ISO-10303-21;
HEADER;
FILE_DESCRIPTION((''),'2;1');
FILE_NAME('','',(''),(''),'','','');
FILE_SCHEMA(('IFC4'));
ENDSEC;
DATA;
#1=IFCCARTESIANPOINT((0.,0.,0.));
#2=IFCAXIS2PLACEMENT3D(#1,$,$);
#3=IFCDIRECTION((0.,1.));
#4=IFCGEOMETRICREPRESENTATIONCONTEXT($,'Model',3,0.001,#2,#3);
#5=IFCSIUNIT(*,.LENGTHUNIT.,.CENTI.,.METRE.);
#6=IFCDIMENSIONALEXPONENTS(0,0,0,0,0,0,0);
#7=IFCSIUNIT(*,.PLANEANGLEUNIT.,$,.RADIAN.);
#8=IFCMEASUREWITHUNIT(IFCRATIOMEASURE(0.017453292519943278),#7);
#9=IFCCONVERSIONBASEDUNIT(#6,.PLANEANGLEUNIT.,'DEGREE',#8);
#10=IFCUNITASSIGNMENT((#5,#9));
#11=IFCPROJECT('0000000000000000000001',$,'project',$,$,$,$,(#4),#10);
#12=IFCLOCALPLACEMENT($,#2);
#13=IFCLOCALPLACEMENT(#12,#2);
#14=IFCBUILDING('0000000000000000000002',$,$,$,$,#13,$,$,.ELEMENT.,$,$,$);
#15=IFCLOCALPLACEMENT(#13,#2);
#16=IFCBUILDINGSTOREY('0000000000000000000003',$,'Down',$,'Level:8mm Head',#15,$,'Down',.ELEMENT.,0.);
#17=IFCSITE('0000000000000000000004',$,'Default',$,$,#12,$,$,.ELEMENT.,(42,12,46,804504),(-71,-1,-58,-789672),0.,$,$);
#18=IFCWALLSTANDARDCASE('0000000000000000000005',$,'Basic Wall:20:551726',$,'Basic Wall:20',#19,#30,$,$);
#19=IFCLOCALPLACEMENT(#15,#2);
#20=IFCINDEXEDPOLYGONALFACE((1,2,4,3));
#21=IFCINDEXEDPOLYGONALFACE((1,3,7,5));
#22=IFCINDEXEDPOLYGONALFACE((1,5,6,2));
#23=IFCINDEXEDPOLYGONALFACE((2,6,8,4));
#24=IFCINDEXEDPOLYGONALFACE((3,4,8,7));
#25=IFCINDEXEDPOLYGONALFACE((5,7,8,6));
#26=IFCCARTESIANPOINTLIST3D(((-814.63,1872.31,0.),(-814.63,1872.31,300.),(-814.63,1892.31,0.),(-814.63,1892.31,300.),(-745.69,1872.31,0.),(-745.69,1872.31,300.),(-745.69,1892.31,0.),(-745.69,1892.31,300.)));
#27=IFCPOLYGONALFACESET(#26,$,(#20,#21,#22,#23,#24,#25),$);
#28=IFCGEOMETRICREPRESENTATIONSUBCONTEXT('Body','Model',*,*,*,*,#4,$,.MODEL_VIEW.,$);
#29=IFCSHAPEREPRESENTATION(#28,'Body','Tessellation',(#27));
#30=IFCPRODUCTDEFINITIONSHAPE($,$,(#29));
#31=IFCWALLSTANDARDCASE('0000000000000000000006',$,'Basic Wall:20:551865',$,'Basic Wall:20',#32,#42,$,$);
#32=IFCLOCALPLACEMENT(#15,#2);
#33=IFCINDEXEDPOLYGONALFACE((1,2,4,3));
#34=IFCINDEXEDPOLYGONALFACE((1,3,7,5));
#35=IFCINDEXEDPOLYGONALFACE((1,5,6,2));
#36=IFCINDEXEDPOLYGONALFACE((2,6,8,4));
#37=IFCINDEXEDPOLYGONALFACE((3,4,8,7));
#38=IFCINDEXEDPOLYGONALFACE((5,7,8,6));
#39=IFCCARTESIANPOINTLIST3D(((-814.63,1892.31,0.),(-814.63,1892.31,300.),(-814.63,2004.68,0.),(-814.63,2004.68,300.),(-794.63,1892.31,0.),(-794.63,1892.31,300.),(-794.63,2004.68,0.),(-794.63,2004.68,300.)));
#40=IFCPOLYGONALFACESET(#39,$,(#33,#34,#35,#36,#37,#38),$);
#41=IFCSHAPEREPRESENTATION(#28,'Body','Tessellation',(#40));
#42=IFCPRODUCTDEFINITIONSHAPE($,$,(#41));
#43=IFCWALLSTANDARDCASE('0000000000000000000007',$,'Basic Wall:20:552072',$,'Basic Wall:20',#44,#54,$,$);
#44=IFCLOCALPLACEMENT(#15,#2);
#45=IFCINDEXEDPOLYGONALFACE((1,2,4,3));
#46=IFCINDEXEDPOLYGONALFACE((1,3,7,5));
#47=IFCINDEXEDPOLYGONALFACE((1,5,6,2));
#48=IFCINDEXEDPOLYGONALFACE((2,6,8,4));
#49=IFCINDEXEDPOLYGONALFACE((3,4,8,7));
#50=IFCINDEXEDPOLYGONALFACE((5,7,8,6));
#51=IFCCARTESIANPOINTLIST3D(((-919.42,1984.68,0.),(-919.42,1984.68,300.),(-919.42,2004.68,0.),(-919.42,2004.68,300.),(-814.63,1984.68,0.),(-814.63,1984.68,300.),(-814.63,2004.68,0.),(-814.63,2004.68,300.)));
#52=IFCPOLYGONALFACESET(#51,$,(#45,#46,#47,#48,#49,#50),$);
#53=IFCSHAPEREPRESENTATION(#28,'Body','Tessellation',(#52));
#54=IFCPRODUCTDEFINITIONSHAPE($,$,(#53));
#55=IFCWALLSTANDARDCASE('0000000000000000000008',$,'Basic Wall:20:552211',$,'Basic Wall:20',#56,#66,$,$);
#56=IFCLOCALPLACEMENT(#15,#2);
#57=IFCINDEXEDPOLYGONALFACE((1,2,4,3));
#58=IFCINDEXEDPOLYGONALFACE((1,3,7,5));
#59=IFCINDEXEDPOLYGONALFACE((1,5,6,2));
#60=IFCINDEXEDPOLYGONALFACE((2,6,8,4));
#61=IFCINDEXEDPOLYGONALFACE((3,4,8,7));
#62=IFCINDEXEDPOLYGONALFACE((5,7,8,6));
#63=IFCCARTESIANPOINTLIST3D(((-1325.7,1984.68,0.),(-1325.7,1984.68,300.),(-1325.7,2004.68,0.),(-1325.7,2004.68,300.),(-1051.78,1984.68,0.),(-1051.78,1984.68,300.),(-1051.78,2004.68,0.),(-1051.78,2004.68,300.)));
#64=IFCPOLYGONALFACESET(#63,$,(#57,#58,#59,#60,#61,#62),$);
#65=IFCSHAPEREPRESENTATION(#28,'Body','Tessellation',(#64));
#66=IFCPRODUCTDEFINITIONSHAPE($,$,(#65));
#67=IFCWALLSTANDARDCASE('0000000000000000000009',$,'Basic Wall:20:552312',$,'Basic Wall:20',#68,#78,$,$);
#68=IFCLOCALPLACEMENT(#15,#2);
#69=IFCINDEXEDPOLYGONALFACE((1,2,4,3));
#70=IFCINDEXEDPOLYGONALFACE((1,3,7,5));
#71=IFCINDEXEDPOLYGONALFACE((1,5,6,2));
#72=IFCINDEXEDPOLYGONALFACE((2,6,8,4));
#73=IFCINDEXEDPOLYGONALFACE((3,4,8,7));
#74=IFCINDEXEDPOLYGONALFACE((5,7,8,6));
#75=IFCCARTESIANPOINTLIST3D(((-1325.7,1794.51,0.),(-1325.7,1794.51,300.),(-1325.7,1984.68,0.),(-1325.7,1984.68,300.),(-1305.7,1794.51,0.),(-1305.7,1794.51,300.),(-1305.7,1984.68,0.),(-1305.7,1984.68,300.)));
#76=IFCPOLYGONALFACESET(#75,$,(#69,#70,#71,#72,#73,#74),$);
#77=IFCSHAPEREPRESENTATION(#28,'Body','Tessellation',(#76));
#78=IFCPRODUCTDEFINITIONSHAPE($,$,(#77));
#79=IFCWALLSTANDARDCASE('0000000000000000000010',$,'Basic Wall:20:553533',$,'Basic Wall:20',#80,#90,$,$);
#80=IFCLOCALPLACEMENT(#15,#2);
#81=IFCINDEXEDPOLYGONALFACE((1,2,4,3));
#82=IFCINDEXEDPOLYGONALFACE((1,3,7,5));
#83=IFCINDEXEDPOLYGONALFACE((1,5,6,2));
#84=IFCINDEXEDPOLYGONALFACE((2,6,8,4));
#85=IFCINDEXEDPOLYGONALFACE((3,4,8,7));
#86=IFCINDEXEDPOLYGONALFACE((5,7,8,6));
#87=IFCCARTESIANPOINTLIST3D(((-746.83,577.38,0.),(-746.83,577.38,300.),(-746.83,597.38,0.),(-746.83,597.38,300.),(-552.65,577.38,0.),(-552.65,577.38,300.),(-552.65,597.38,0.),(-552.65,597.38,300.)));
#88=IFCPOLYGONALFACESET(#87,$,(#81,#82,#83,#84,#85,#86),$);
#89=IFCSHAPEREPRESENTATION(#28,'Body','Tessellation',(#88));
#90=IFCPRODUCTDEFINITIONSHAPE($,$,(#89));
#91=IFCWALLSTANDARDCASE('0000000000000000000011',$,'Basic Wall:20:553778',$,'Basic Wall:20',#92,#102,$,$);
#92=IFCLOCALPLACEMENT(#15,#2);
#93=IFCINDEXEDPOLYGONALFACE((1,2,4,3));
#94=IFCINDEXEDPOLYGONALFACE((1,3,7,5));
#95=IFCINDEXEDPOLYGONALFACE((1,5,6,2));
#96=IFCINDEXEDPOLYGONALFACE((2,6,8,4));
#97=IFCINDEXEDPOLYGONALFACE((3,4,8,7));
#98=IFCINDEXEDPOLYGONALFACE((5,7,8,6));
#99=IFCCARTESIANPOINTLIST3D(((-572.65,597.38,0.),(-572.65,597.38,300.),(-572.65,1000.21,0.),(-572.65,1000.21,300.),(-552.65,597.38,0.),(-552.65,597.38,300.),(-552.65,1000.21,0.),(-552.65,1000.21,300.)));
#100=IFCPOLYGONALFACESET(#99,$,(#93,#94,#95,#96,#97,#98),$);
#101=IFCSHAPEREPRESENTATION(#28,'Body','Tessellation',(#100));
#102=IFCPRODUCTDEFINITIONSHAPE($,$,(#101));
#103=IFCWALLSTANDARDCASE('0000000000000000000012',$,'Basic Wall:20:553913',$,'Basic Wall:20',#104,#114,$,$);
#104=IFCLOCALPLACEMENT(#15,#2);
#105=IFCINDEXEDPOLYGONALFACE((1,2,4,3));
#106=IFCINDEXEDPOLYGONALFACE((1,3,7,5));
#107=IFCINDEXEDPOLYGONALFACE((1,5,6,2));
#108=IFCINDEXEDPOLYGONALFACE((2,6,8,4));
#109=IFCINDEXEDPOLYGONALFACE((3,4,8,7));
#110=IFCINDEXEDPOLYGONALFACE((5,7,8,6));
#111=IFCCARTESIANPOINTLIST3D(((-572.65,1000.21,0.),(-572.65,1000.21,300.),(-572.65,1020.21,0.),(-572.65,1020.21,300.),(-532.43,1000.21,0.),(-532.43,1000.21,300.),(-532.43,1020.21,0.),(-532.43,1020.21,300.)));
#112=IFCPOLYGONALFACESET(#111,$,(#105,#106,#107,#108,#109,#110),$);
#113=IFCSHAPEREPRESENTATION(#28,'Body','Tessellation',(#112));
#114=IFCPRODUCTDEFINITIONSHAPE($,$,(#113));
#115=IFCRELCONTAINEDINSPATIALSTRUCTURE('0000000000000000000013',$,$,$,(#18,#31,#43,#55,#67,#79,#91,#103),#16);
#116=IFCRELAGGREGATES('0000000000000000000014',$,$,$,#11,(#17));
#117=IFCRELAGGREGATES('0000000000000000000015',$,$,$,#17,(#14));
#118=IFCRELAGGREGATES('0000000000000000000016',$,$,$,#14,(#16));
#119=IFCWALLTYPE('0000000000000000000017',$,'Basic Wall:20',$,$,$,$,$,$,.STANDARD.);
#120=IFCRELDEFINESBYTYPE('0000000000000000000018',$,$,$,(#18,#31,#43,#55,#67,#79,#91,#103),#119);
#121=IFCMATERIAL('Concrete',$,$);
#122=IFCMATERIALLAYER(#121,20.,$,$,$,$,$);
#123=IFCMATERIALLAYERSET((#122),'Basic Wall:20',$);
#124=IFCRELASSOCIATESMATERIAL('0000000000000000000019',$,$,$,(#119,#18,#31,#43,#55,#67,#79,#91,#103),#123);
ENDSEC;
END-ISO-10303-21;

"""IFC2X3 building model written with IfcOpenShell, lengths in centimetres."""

from ifc_helpers import new_model, entity, si_unit, converted_unit, direction, frame, frame_2d, origin, place, context, subcontext, project, spatial, rectangle, extrude, material, layer, layer_set, layer_usage, type_object, element, save


model = new_model("IFC2X3")

# Units and contexts
model_context = context("Model", 3, precision=0.001, world=origin(), true_north=direction((0.0, 1.0)))
body_context = subcontext(model_context, "Body", "Model", "MODEL_VIEW")
ifc_project = project(units=[si_unit("LENGTHUNIT", "METRE", prefix="CENTI"), converted_unit("PLANEANGLEUNIT", "DEGREE", entity("IfcRatioMeasure", 0.017453292519943278), si_unit("PLANEANGLEUNIT", "RADIAN"), dimensions=[0, 0, 0, 0, 0, 0, 0])], contexts=[model_context])

# Site, building, storey
site_placement = place(None, origin())
site = spatial("IfcSite", under=ifc_project, at=site_placement, Name="Default", CompositionType="ELEMENT", RefLatitude=(42, 12, 46, 804504), RefLongitude=(-71, -1, -58, -789672), RefElevation=0.0)
building_placement = place(site_placement, origin())
building = spatial("IfcBuilding", under=site, at=building_placement, CompositionType="ELEMENT")
storey_placement = place(building_placement, origin())
storey = spatial("IfcBuildingStorey", under=building, at=storey_placement, Name="Down", ObjectType="Level:8mm Head", LongName="Down", CompositionType="ELEMENT", Elevation=0.0)

# Walls
ifc_material = material(Name="Concrete")
ifc_layer_1 = layer(ifc_material, 20.0)
ifc_layer_set_1 = layer_set([ifc_layer_1], Name="Basic Wall:20")
wall_type_1 = type_object("IfcWallType", Name="Basic Wall:20", PredefinedType="STANDARD", material=ifc_layer_set_1)
ifc_layer_usage_1 = layer_usage(ifc_layer_set_1, "AXIS2", "NEGATIVE", 10.0)
wall_1_placement = place(storey_placement, frame((-745.69, 1882.31, 0.0), z_axis=(0.0, 0.0, 1.0), x_axis=(-1.0, 0.0, 0.0)))
element("IfcWallStandardCase", 1, at=wall_1_placement, inside=storey, type_object=wall_type_1, material=ifc_layer_usage_1, Name="Basic Wall:20:551726", ObjectType="Basic Wall:20", context=body_context, shape_type="SweptSolid", body=[
    extrude(rectangle(XDim=68.94, YDim=20.0, at=frame_2d((34.47, 0.0), x_axis=(-1.0, 0.0))), origin(), (0.0, 0.0, 1.0), 300.0),
])
ifc_layer_usage_2 = layer_usage(ifc_layer_set_1, "AXIS2", "NEGATIVE", 10.0)
wall_2_placement = place(storey_placement, frame((-804.63, 1892.31, 0.0), z_axis=(0.0, 0.0, 1.0), x_axis=(0.0, 1.0, 0.0)))
element("IfcWallStandardCase", 2, at=wall_2_placement, inside=storey, type_object=wall_type_1, material=ifc_layer_usage_2, Name="Basic Wall:20:551865", ObjectType="Basic Wall:20", context=body_context, shape_type="SweptSolid", body=[
    extrude(rectangle(XDim=112.36, YDim=20.0, at=frame_2d((56.18, 0.0), x_axis=(-1.0, 0.0))), origin(), (0.0, 0.0, 1.0), 300.0),
])
ifc_layer_usage_3 = layer_usage(ifc_layer_set_1, "AXIS2", "POSITIVE", -10.0)
wall_3_placement = place(storey_placement, frame((-814.63, 1994.68, 0.0), z_axis=(0.0, 0.0, 1.0), x_axis=(-1.0, 0.0, 0.0)))
element("IfcWallStandardCase", 3, at=wall_3_placement, inside=storey, type_object=wall_type_1, material=ifc_layer_usage_3, Name="Basic Wall:20:552072", ObjectType="Basic Wall:20", context=body_context, shape_type="SweptSolid", body=[
    extrude(rectangle(XDim=104.79, YDim=20.0, at=frame_2d((52.39, 0.0), x_axis=(-1.0, 0.0))), origin(), (0.0, 0.0, 1.0), 300.0),
])
ifc_layer_usage_4 = layer_usage(ifc_layer_set_1, "AXIS2", "POSITIVE", -10.0)
wall_4_placement = place(storey_placement, frame((-1051.78, 1994.68, 0.0), z_axis=(0.0, 0.0, 1.0), x_axis=(-1.0, 0.0, 0.0)))
element("IfcWallStandardCase", 4, at=wall_4_placement, inside=storey, type_object=wall_type_1, material=ifc_layer_usage_4, Name="Basic Wall:20:552211", ObjectType="Basic Wall:20", context=body_context, shape_type="SweptSolid", body=[
    extrude(rectangle(XDim=273.92, YDim=20.0, at=frame_2d((136.96, 0.0), x_axis=(-1.0, 0.0))), origin(), (0.0, 0.0, 1.0), 300.0),
])
ifc_layer_usage_5 = layer_usage(ifc_layer_set_1, "AXIS2", "POSITIVE", -10.0)
wall_5_placement = place(storey_placement, frame((-1315.7, 1984.68, 0.0), z_axis=(0.0, 0.0, 1.0), x_axis=(0.0, -1.0, 0.0)))
element("IfcWallStandardCase", 5, at=wall_5_placement, inside=storey, type_object=wall_type_1, material=ifc_layer_usage_5, Name="Basic Wall:20:552312", ObjectType="Basic Wall:20", context=body_context, shape_type="SweptSolid", body=[
    extrude(rectangle(XDim=190.16, YDim=20.0, at=frame_2d((95.08, 0.0), x_axis=(-1.0, 0.0))), origin(), (0.0, 0.0, 1.0), 300.0),
])
ifc_layer_usage_6 = layer_usage(ifc_layer_set_1, "AXIS2", "NEGATIVE", 10.0)
wall_6_placement = place(storey_placement, frame((-746.83, 587.38, 0.0)))
element("IfcWallStandardCase", 6, at=wall_6_placement, inside=storey, type_object=wall_type_1, material=ifc_layer_usage_6, Name="Basic Wall:20:553533", ObjectType="Basic Wall:20", context=body_context, shape_type="SweptSolid", body=[
    extrude(rectangle(XDim=194.17, YDim=20.0, at=frame_2d((97.09, 0.0), x_axis=(-1.0, 0.0))), origin(), (0.0, 0.0, 1.0), 300.0),
])
ifc_layer_usage_7 = layer_usage(ifc_layer_set_1, "AXIS2", "POSITIVE", -10.0)
wall_7_placement = place(storey_placement, frame((-562.65, 597.38, 0.0), z_axis=(0.0, 0.0, 1.0), x_axis=(0.0, 1.0, 0.0)))
element("IfcWallStandardCase", 7, at=wall_7_placement, inside=storey, type_object=wall_type_1, material=ifc_layer_usage_7, Name="Basic Wall:20:553778", ObjectType="Basic Wall:20", context=body_context, shape_type="SweptSolid", body=[
    extrude(rectangle(XDim=402.83, YDim=20.0, at=frame_2d((201.42, 0.0), x_axis=(-1.0, 0.0))), origin(), (0.0, 0.0, 1.0), 300.0),
])
ifc_layer_usage_8 = layer_usage(ifc_layer_set_1, "AXIS2", "NEGATIVE", 10.0)
wall_8_placement = place(storey_placement, frame((-572.65, 1010.21, 0.0)))
element("IfcWallStandardCase", 8, at=wall_8_placement, inside=storey, type_object=wall_type_1, material=ifc_layer_usage_8, Name="Basic Wall:20:553913", ObjectType="Basic Wall:20", context=body_context, shape_type="SweptSolid", body=[
    extrude(rectangle(XDim=40.22, YDim=20.0, at=frame_2d((20.11, 0.0), x_axis=(-1.0, 0.0))), origin(), (0.0, 0.0, 1.0), 300.0),
])

save(model, "model.ifc")
